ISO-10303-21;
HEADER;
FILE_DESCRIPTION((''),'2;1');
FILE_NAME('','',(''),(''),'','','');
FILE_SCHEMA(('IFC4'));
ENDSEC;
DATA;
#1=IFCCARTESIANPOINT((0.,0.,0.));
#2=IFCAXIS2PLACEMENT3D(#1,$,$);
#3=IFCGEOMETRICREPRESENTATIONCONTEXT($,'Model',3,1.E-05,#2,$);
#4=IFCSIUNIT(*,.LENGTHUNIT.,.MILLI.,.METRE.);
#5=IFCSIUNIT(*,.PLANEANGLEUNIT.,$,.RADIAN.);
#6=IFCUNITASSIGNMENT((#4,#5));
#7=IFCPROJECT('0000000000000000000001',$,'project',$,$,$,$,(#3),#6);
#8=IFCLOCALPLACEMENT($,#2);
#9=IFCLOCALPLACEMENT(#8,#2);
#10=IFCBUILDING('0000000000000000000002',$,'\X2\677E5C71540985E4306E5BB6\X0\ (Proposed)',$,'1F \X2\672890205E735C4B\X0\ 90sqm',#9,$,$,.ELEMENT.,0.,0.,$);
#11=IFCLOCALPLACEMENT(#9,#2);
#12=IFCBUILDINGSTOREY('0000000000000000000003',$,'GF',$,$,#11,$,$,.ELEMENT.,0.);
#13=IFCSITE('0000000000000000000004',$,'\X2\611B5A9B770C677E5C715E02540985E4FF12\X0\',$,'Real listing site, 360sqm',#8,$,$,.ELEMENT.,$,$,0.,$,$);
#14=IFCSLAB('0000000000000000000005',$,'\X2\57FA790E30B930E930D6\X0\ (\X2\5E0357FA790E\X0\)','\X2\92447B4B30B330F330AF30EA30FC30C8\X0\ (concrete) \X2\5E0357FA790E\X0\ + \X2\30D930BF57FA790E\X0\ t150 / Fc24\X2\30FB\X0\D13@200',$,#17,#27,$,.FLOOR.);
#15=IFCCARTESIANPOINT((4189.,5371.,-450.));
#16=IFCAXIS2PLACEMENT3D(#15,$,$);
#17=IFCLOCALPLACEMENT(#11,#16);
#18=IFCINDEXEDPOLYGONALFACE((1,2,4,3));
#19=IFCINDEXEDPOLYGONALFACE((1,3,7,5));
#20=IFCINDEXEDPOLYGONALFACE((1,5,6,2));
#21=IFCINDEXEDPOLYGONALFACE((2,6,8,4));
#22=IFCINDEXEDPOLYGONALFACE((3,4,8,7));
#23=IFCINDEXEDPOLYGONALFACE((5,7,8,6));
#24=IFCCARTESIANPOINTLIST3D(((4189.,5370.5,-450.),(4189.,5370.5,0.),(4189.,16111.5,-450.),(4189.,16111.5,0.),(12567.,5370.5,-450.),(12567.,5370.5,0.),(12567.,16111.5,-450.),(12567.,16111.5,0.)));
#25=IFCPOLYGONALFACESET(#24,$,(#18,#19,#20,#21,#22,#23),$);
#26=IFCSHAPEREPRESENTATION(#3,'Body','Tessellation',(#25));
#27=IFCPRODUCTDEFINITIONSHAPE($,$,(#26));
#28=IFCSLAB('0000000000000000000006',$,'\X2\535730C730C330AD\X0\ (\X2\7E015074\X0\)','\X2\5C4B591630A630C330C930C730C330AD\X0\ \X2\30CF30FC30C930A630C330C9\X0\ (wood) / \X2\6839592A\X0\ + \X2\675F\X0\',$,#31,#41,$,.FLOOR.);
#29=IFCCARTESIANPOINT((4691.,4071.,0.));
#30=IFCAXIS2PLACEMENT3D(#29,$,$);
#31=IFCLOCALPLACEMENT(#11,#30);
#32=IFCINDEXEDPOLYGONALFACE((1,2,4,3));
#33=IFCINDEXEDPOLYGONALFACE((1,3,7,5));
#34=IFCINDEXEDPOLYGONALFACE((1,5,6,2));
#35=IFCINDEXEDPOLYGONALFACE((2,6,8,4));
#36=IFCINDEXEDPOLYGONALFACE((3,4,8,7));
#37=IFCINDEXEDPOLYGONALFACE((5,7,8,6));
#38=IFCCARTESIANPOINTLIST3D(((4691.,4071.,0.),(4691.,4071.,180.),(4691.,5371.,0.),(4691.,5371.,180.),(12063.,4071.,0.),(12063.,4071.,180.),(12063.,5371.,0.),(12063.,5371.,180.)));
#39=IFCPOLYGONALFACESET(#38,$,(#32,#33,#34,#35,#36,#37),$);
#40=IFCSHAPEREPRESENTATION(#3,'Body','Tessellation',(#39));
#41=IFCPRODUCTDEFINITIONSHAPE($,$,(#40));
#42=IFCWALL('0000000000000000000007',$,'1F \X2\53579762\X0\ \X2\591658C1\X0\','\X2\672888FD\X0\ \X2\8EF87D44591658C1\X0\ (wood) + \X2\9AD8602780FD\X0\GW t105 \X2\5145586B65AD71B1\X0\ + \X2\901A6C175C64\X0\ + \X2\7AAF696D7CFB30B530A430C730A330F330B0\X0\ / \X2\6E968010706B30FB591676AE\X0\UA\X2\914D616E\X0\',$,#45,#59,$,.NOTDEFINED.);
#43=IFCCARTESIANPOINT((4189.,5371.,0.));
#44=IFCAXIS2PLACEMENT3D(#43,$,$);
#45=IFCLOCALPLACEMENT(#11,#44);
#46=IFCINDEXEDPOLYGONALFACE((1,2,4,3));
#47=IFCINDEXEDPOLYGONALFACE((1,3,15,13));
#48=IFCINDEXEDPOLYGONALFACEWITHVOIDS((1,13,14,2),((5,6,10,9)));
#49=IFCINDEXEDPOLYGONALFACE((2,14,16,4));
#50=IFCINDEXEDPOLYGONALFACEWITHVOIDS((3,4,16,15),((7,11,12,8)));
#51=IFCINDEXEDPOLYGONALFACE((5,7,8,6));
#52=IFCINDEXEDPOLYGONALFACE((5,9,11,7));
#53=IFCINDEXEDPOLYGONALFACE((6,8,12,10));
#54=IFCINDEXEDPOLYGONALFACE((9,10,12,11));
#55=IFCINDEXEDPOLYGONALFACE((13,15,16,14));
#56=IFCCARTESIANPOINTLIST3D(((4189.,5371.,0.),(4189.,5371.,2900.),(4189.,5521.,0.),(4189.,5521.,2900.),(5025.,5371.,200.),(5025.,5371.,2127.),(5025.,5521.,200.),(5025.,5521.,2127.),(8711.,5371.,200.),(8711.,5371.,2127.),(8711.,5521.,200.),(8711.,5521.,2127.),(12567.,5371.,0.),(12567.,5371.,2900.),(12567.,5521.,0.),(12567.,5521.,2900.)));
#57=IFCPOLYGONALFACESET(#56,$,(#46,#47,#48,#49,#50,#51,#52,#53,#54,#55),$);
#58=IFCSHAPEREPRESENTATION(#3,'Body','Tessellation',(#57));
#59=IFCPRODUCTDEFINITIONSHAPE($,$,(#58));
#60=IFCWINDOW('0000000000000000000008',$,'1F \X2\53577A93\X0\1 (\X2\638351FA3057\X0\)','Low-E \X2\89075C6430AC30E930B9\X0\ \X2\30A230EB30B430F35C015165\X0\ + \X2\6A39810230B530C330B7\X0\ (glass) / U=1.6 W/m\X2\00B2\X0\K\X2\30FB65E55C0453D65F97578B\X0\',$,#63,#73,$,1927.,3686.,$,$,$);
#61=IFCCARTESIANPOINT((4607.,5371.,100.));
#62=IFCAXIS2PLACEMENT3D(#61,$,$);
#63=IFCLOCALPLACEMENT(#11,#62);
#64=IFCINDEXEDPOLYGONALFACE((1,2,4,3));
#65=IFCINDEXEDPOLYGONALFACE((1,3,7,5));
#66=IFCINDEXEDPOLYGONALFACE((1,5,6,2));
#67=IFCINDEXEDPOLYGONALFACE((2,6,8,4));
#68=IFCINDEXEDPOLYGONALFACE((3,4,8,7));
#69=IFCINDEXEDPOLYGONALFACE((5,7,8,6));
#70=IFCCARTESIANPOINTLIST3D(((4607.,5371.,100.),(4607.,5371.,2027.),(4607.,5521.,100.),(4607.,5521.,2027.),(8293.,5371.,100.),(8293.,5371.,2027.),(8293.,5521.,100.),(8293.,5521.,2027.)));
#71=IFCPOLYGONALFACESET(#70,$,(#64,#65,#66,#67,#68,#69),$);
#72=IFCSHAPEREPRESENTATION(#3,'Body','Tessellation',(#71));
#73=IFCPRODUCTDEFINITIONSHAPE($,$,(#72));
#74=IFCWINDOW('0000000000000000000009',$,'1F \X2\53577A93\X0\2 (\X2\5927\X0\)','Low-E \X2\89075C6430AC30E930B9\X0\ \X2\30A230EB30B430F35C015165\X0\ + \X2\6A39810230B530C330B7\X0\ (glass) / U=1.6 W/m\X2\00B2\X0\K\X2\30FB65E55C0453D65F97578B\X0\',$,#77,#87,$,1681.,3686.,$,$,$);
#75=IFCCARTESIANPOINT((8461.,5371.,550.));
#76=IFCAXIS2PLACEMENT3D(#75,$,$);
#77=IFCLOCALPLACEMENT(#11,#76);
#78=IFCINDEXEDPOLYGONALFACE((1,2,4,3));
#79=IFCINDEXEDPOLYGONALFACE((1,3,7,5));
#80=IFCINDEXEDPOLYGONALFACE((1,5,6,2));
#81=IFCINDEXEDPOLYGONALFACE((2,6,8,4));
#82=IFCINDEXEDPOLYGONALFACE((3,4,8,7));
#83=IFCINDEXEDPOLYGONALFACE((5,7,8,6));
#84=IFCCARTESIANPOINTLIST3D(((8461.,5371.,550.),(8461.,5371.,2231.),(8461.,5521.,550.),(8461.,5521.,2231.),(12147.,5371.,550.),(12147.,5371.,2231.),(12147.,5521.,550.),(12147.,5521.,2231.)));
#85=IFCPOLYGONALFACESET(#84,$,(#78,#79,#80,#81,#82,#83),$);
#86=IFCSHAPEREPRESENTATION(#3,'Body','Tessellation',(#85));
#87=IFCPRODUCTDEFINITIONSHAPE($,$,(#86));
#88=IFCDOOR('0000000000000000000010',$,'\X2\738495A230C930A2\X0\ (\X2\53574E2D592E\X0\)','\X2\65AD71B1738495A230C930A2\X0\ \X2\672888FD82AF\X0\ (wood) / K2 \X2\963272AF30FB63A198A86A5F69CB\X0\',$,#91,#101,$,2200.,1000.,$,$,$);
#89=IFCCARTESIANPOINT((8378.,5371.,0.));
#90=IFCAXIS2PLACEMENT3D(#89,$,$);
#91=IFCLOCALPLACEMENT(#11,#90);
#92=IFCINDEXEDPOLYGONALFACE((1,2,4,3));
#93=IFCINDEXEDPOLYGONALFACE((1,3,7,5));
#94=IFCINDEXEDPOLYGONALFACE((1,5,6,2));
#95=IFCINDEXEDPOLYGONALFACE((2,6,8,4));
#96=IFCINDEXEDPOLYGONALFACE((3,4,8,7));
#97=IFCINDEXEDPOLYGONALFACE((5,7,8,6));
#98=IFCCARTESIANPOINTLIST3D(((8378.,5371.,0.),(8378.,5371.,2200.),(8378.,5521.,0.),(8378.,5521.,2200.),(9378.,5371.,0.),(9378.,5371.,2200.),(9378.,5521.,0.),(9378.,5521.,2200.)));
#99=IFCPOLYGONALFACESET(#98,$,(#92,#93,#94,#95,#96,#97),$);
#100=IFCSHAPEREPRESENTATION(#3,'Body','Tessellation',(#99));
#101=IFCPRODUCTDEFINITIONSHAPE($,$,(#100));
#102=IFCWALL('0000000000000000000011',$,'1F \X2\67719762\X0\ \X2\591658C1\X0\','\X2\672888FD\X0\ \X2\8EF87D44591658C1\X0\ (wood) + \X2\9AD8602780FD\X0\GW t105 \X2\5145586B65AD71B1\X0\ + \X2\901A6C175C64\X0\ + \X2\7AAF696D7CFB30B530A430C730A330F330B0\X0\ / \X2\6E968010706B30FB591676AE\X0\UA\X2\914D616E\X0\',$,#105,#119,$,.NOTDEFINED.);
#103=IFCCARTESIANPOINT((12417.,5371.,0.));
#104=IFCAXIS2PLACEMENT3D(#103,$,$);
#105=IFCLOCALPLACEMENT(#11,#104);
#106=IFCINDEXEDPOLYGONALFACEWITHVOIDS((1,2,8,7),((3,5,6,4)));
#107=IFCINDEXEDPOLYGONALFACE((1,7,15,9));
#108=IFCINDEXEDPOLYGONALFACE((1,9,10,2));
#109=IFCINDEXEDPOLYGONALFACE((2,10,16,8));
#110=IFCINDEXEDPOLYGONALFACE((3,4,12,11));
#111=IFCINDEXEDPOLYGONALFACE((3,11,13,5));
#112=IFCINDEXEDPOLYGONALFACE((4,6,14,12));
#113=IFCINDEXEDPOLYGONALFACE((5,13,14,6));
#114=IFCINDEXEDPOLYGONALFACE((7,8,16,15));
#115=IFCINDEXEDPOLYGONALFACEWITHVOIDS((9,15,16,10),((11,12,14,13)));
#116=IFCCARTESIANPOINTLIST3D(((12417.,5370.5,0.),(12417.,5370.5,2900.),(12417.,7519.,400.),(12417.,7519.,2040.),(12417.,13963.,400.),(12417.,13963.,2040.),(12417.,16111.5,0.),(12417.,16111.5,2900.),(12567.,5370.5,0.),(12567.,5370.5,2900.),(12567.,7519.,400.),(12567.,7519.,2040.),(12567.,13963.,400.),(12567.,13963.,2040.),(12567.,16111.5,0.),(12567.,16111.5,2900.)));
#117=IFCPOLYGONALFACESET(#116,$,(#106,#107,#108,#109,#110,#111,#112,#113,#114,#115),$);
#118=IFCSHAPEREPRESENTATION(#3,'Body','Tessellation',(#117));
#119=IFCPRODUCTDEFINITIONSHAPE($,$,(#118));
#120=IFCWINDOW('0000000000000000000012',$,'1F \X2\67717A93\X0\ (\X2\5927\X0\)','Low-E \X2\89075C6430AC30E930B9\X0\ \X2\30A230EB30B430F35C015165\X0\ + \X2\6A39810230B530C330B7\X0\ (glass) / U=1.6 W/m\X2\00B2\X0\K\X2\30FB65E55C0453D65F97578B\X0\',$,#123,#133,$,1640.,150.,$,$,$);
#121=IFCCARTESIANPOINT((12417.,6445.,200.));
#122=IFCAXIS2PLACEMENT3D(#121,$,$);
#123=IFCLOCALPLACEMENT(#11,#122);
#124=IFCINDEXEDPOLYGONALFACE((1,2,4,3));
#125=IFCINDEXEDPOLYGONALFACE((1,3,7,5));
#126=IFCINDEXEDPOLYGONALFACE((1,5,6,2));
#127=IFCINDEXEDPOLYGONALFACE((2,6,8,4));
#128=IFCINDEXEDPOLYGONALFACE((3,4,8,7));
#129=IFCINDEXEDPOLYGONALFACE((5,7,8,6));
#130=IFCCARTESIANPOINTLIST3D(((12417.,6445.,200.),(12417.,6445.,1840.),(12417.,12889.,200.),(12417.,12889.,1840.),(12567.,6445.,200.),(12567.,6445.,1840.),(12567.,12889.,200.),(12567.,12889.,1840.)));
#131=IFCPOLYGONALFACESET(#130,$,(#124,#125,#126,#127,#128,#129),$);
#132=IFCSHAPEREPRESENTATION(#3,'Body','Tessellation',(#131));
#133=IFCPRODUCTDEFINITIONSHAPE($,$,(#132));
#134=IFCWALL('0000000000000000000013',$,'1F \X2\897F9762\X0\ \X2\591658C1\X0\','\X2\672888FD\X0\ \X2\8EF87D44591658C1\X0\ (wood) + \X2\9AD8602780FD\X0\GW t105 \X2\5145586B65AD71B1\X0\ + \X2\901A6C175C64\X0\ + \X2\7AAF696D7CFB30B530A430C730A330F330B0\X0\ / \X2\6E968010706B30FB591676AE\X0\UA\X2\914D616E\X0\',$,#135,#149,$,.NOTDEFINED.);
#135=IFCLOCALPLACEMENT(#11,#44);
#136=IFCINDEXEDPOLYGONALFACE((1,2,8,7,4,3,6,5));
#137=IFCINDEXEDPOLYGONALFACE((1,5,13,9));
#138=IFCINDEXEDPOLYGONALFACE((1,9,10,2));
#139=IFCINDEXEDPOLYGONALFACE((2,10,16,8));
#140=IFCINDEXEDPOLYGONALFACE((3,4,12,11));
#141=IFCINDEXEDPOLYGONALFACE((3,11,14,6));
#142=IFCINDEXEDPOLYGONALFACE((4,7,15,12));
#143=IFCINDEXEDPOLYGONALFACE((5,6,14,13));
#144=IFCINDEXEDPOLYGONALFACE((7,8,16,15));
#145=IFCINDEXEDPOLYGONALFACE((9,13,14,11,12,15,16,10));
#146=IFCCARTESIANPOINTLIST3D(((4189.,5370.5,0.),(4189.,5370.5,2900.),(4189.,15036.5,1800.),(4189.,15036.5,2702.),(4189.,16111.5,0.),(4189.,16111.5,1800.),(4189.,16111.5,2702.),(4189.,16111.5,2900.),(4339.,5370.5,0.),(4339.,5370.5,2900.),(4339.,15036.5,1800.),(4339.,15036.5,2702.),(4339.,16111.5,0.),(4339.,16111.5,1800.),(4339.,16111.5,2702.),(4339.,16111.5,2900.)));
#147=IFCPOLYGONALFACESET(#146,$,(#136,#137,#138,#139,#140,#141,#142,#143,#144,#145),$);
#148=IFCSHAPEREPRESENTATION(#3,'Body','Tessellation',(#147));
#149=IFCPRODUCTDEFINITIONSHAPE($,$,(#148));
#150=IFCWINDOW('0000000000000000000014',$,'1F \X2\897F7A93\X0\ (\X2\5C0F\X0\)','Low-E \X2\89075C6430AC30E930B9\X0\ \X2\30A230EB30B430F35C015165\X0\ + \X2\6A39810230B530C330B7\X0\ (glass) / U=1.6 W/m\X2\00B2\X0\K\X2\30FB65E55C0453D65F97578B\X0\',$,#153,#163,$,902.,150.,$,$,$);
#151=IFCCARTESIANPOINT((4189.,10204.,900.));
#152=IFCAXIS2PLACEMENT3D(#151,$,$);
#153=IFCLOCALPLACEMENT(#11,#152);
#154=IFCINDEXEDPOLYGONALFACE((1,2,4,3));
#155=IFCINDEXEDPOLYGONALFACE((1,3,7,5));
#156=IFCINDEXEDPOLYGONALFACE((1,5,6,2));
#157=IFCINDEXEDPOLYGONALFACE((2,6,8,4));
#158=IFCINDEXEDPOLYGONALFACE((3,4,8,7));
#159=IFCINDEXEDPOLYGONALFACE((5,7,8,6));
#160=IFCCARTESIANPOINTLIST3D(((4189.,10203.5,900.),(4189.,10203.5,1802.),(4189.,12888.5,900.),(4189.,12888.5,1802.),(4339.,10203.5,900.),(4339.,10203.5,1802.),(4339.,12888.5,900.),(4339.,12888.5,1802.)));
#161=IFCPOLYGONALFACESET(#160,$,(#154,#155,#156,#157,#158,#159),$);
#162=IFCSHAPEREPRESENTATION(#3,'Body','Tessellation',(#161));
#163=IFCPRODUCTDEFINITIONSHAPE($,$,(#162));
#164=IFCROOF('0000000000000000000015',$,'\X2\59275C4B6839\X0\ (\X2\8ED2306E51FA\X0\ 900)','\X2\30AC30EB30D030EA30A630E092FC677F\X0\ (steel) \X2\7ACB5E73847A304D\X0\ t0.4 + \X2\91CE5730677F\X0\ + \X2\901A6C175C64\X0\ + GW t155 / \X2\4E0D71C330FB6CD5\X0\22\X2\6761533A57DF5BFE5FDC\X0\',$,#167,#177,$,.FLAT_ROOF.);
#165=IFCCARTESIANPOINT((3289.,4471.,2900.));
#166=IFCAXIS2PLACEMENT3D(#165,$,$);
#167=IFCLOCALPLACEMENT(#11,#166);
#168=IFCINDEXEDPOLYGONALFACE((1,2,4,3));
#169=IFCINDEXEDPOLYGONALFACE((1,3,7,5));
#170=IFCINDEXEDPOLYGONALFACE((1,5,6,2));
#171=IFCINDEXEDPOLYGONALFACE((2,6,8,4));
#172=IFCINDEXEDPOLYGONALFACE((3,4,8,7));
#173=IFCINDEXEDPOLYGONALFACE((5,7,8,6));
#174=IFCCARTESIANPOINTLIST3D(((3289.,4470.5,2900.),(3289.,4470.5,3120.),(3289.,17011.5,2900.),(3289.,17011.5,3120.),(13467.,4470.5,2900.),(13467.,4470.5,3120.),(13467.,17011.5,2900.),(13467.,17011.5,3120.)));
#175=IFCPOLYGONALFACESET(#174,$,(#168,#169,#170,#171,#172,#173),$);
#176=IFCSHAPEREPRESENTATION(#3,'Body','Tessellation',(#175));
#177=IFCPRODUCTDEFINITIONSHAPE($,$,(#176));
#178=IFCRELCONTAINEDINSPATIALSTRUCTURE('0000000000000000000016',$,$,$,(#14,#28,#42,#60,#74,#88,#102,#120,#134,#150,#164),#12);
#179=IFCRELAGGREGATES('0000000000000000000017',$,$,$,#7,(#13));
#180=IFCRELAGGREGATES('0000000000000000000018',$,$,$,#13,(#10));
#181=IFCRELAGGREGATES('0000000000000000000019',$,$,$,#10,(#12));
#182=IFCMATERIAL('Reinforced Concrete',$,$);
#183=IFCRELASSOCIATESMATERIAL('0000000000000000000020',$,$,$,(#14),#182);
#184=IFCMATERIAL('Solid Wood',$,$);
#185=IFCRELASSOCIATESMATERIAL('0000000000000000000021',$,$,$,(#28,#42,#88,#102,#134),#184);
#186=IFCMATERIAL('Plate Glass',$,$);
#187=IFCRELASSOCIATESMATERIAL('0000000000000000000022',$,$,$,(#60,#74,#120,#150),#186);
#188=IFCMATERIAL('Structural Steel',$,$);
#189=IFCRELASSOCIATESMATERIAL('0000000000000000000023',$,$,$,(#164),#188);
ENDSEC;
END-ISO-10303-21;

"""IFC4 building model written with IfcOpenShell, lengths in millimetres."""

from ifc_helpers import new_model, si_unit, frame, frame_2d, origin, place, context, project, spatial, rectangle, extrude, material, element, fill, save


model = new_model("IFC4")

# Units and contexts
model_context = context("Model", 3, precision=1e-05, world=origin())
ifc_project = project(units=[si_unit("LENGTHUNIT", "METRE", prefix="MILLI"), si_unit("PLANEANGLEUNIT", "RADIAN")], contexts=[model_context])

# Site, building, storey
site_placement = place(None, origin())
site = spatial("IfcSite", under=ifc_project, at=site_placement, Name="愛媛県松山市吉藤２", ObjectType="Real listing site, 360sqm", CompositionType="ELEMENT", RefElevation=0.0)
building_placement = place(site_placement, origin())
building = spatial("IfcBuilding", under=site, at=building_placement, Name="松山吉藤の家 (Proposed)", ObjectType="1F 木造平屋 90sqm", CompositionType="ELEMENT", ElevationOfRefHeight=0.0, ElevationOfTerrain=0.0)
storey_placement = place(building_placement, origin())
storey = spatial("IfcBuildingStorey", under=building, at=storey_placement, Name="GF", CompositionType="ELEMENT", Elevation=0.0)

# Slabs
ifc_material_1 = material(Name="Reinforced Concrete")
slab_1_placement = place(storey_placement, frame((4189.0, 5371.0, -450.0)))
element("IfcSlab", 1, at=slab_1_placement, inside=storey, material=ifc_material_1, Name="基礎スラブ (布基礎)", Description="鉄筋コンクリート (concrete) 布基礎 + ベタ基礎 t150 / Fc24・D13@200", PredefinedType="FLOOR", context=model_context, shape_type="SweptSolid", body=[
    extrude(rectangle(XDim=8378.0, YDim=10741.0, at=frame_2d((4189.0, 5370.0))), frame((4189.0, 5371.0, -450.0)), (0.0, 0.0, 1.0), 450.0),
])
ifc_material_2 = material(Name="Solid Wood")
slab_2_placement = place(storey_placement, frame((4691.0, 4071.0, 0.0)))
element("IfcSlab", 2, at=slab_2_placement, inside=storey, material=ifc_material_2, Name="南デッキ (縁側)", Description="屋外ウッドデッキ ハードウッド (wood) / 根太 + 束", PredefinedType="FLOOR", context=model_context, shape_type="SweptSolid", body=[
    extrude(rectangle(XDim=7372.0, YDim=1300.0, at=frame_2d((3686.0, 650.0))), frame((4691.0, 4071.0, 0.0)), (0.0, 0.0, 1.0), 180.0),
])

# Wall, openings, windows, door
wall_1_placement = place(storey_placement, frame((4189.0, 5371.0, 0.0)))
wall_1 = element("IfcWall", 3, at=wall_1_placement, inside=storey, material=ifc_material_2, Name="1F 南面 外壁", Description="木製 軸組外壁 (wood) + 高性能GW t105 充填断熱 + 通気層 + 窯業系サイディング / 準耐火・外皮UA配慮", PredefinedType="NOTDEFINED", context=model_context, shape_type="SweptSolid", body=[
    extrude(rectangle(XDim=8378.0, YDim=150.0, at=frame_2d((4189.0, 75.0))), frame((4189.0, 5371.0, 0.0)), (0.0, 0.0, 1.0), 2900.0),
])
opening_1_placement = place(storey_placement, frame((4607.0, 5371.0, 100.0)))
opening_1 = element("IfcOpeningElement", 4, at=opening_1_placement, cuts=wall_1, PredefinedType="NOTDEFINED", context=model_context, shape_type="SweptSolid", body=[
    extrude(rectangle(XDim=3686.0, YDim=150.0, at=frame_2d((1843.0, 75.0))), frame((4607.0, 5371.0, 100.0)), (0.0, 0.0, 1.0), 1927.0),
])
opening_2_placement = place(storey_placement, frame((8461.0, 5371.0, 550.0)))
opening_2 = element("IfcOpeningElement", 5, at=opening_2_placement, cuts=wall_1, PredefinedType="NOTDEFINED", context=model_context, shape_type="SweptSolid", body=[
    extrude(rectangle(XDim=3686.0, YDim=150.0, at=frame_2d((1843.0, 75.0))), frame((8461.0, 5371.0, 550.0)), (0.0, 0.0, 1.0), 1681.0),
])
opening_3_placement = place(storey_placement, frame((8378.0, 5371.0, 0.0)))
opening_3 = element("IfcOpeningElement", 6, at=opening_3_placement, cuts=wall_1, PredefinedType="NOTDEFINED", context=model_context, shape_type="SweptSolid", body=[
    extrude(rectangle(XDim=1000.0, YDim=150.0, at=frame_2d((500.0, 75.0))), frame((8378.0, 5371.0, 0.0)), (0.0, 0.0, 1.0), 2200.0),
])
ifc_material_3 = material(Name="Plate Glass")
window_1_placement = place(storey_placement, frame((4607.0, 5371.0, 100.0)))
window_1 = element("IfcWindow", 7, at=window_1_placement, inside=storey, material=ifc_material_3, Name="1F 南窓1 (掃出し)", Description="Low-E 複層ガラス アルゴン封入 + 樹脂サッシ (glass) / U=1.6 W/m²K・日射取得型", OverallHeight=1927.0, OverallWidth=3686.0, context=model_context, shape_type="SweptSolid", body=[
    extrude(rectangle(XDim=3686.0, YDim=150.0, at=frame_2d((1843.0, 75.0))), frame((4607.0, 5371.0, 100.0)), (0.0, 0.0, 1.0), 1927.0),
])
fill(opening_1, window_1)
window_2_placement = place(storey_placement, frame((8461.0, 5371.0, 550.0)))
window_2 = element("IfcWindow", 8, at=window_2_placement, inside=storey, material=ifc_material_3, Name="1F 南窓2 (大)", Description="Low-E 複層ガラス アルゴン封入 + 樹脂サッシ (glass) / U=1.6 W/m²K・日射取得型", OverallHeight=1681.0, OverallWidth=3686.0, context=model_context, shape_type="SweptSolid", body=[
    extrude(rectangle(XDim=3686.0, YDim=150.0, at=frame_2d((1843.0, 75.0))), frame((8461.0, 5371.0, 550.0)), (0.0, 0.0, 1.0), 1681.0),
])
fill(opening_2, window_2)
door_placement = place(storey_placement, frame((8378.0, 5371.0, 0.0)))
door = element("IfcDoor", 9, at=door_placement, inside=storey, material=ifc_material_2, Name="玄関ドア (南中央)", Description="断熱玄関ドア 木製芯 (wood) / K2 防犯・採風機構", OverallHeight=2200.0, OverallWidth=1000.0, context=model_context, shape_type="SweptSolid", body=[
    extrude(rectangle(XDim=1000.0, YDim=150.0, at=frame_2d((500.0, 75.0))), frame((8378.0, 5371.0, 0.0)), (0.0, 0.0, 1.0), 2200.0),
])
fill(opening_3, door)

# Walls, openings, windows
wall_2_placement = place(storey_placement, frame((12417.0, 5371.0, 0.0)))
wall_2 = element("IfcWall", 10, at=wall_2_placement, inside=storey, material=ifc_material_2, Name="1F 東面 外壁", Description="木製 軸組外壁 (wood) + 高性能GW t105 充填断熱 + 通気層 + 窯業系サイディング / 準耐火・外皮UA配慮", PredefinedType="NOTDEFINED", context=model_context, shape_type="SweptSolid", body=[
    extrude(rectangle(XDim=150.0, YDim=10741.0, at=frame_2d((75.0, 5370.0))), frame((12417.0, 5371.0, 0.0)), (0.0, 0.0, 1.0), 2900.0),
])
opening_4_placement = place(storey_placement, frame((12417.0, 6445.0, 200.0)))
opening_4 = element("IfcOpeningElement", 11, at=opening_4_placement, cuts=wall_2, PredefinedType="NOTDEFINED", context=model_context, shape_type="SweptSolid", body=[
    extrude(rectangle(XDim=150.0, YDim=6444.0, at=frame_2d((75.0, 3222.0))), frame((12417.0, 6445.0, 200.0)), (0.0, 0.0, 1.0), 1640.0),
])
window_3_placement = place(storey_placement, frame((12417.0, 6445.0, 200.0)))
window_3 = element("IfcWindow", 12, at=window_3_placement, inside=storey, material=ifc_material_3, Name="1F 東窓 (大)", Description="Low-E 複層ガラス アルゴン封入 + 樹脂サッシ (glass) / U=1.6 W/m²K・日射取得型", OverallHeight=1640.0, OverallWidth=150.0, context=model_context, shape_type="SweptSolid", body=[
    extrude(rectangle(XDim=150.0, YDim=6444.0, at=frame_2d((75.0, 3222.0))), frame((12417.0, 6445.0, 200.0)), (0.0, 0.0, 1.0), 1640.0),
])
fill(opening_4, window_3)
wall_3_placement = place(storey_placement, frame((4189.0, 5371.0, 0.0)))
wall_3 = element("IfcWall", 13, at=wall_3_placement, inside=storey, material=ifc_material_2, Name="1F 西面 外壁", Description="木製 軸組外壁 (wood) + 高性能GW t105 充填断熱 + 通気層 + 窯業系サイディング / 準耐火・外皮UA配慮", PredefinedType="NOTDEFINED", context=model_context, shape_type="SweptSolid", body=[
    extrude(rectangle(XDim=150.0, YDim=10741.0, at=frame_2d((75.0, 5370.0))), frame((4189.0, 5371.0, 0.0)), (0.0, 0.0, 1.0), 2900.0),
])
opening_5_placement = place(storey_placement, frame((4189.0, 10204.0, 900.0)))
opening_5 = element("IfcOpeningElement", 14, at=opening_5_placement, cuts=wall_3, PredefinedType="NOTDEFINED", context=model_context, shape_type="SweptSolid", body=[
    extrude(rectangle(XDim=150.0, YDim=2685.0, at=frame_2d((75.0, 1342.0))), frame((4189.0, 10204.0, 900.0)), (0.0, 0.0, 1.0), 902.0),
])
window_4_placement = place(storey_placement, frame((4189.0, 10204.0, 900.0)))
window_4 = element("IfcWindow", 15, at=window_4_placement, inside=storey, material=ifc_material_3, Name="1F 西窓 (小)", Description="Low-E 複層ガラス アルゴン封入 + 樹脂サッシ (glass) / U=1.6 W/m²K・日射取得型", OverallHeight=902.0, OverallWidth=150.0, context=model_context, shape_type="SweptSolid", body=[
    extrude(rectangle(XDim=150.0, YDim=2685.0, at=frame_2d((75.0, 1342.0))), frame((4189.0, 10204.0, 900.0)), (0.0, 0.0, 1.0), 902.0),
])
fill(opening_5, window_4)

# Roof
ifc_material_4 = material(Name="Structural Steel")
roof_placement = place(storey_placement, frame((3289.0, 4471.0, 2900.0)))
element("IfcRoof", 16, at=roof_placement, inside=storey, material=ifc_material_4, Name="大屋根 (軒の出 900)", Description="ガルバリウム鋼板 (steel) 立平葺き t0.4 + 野地板 + 通気層 + GW t155 / 不燃・法22条区域対応", PredefinedType="FLAT_ROOF", context=model_context, shape_type="SweptSolid", body=[
    extrude(rectangle(XDim=10178.0, YDim=12541.0, at=frame_2d((5089.0, 6270.0))), frame((3289.0, 4471.0, 2900.0)), (0.0, 0.0, 1.0), 220.0),
])

save(model, "model.ifc")
